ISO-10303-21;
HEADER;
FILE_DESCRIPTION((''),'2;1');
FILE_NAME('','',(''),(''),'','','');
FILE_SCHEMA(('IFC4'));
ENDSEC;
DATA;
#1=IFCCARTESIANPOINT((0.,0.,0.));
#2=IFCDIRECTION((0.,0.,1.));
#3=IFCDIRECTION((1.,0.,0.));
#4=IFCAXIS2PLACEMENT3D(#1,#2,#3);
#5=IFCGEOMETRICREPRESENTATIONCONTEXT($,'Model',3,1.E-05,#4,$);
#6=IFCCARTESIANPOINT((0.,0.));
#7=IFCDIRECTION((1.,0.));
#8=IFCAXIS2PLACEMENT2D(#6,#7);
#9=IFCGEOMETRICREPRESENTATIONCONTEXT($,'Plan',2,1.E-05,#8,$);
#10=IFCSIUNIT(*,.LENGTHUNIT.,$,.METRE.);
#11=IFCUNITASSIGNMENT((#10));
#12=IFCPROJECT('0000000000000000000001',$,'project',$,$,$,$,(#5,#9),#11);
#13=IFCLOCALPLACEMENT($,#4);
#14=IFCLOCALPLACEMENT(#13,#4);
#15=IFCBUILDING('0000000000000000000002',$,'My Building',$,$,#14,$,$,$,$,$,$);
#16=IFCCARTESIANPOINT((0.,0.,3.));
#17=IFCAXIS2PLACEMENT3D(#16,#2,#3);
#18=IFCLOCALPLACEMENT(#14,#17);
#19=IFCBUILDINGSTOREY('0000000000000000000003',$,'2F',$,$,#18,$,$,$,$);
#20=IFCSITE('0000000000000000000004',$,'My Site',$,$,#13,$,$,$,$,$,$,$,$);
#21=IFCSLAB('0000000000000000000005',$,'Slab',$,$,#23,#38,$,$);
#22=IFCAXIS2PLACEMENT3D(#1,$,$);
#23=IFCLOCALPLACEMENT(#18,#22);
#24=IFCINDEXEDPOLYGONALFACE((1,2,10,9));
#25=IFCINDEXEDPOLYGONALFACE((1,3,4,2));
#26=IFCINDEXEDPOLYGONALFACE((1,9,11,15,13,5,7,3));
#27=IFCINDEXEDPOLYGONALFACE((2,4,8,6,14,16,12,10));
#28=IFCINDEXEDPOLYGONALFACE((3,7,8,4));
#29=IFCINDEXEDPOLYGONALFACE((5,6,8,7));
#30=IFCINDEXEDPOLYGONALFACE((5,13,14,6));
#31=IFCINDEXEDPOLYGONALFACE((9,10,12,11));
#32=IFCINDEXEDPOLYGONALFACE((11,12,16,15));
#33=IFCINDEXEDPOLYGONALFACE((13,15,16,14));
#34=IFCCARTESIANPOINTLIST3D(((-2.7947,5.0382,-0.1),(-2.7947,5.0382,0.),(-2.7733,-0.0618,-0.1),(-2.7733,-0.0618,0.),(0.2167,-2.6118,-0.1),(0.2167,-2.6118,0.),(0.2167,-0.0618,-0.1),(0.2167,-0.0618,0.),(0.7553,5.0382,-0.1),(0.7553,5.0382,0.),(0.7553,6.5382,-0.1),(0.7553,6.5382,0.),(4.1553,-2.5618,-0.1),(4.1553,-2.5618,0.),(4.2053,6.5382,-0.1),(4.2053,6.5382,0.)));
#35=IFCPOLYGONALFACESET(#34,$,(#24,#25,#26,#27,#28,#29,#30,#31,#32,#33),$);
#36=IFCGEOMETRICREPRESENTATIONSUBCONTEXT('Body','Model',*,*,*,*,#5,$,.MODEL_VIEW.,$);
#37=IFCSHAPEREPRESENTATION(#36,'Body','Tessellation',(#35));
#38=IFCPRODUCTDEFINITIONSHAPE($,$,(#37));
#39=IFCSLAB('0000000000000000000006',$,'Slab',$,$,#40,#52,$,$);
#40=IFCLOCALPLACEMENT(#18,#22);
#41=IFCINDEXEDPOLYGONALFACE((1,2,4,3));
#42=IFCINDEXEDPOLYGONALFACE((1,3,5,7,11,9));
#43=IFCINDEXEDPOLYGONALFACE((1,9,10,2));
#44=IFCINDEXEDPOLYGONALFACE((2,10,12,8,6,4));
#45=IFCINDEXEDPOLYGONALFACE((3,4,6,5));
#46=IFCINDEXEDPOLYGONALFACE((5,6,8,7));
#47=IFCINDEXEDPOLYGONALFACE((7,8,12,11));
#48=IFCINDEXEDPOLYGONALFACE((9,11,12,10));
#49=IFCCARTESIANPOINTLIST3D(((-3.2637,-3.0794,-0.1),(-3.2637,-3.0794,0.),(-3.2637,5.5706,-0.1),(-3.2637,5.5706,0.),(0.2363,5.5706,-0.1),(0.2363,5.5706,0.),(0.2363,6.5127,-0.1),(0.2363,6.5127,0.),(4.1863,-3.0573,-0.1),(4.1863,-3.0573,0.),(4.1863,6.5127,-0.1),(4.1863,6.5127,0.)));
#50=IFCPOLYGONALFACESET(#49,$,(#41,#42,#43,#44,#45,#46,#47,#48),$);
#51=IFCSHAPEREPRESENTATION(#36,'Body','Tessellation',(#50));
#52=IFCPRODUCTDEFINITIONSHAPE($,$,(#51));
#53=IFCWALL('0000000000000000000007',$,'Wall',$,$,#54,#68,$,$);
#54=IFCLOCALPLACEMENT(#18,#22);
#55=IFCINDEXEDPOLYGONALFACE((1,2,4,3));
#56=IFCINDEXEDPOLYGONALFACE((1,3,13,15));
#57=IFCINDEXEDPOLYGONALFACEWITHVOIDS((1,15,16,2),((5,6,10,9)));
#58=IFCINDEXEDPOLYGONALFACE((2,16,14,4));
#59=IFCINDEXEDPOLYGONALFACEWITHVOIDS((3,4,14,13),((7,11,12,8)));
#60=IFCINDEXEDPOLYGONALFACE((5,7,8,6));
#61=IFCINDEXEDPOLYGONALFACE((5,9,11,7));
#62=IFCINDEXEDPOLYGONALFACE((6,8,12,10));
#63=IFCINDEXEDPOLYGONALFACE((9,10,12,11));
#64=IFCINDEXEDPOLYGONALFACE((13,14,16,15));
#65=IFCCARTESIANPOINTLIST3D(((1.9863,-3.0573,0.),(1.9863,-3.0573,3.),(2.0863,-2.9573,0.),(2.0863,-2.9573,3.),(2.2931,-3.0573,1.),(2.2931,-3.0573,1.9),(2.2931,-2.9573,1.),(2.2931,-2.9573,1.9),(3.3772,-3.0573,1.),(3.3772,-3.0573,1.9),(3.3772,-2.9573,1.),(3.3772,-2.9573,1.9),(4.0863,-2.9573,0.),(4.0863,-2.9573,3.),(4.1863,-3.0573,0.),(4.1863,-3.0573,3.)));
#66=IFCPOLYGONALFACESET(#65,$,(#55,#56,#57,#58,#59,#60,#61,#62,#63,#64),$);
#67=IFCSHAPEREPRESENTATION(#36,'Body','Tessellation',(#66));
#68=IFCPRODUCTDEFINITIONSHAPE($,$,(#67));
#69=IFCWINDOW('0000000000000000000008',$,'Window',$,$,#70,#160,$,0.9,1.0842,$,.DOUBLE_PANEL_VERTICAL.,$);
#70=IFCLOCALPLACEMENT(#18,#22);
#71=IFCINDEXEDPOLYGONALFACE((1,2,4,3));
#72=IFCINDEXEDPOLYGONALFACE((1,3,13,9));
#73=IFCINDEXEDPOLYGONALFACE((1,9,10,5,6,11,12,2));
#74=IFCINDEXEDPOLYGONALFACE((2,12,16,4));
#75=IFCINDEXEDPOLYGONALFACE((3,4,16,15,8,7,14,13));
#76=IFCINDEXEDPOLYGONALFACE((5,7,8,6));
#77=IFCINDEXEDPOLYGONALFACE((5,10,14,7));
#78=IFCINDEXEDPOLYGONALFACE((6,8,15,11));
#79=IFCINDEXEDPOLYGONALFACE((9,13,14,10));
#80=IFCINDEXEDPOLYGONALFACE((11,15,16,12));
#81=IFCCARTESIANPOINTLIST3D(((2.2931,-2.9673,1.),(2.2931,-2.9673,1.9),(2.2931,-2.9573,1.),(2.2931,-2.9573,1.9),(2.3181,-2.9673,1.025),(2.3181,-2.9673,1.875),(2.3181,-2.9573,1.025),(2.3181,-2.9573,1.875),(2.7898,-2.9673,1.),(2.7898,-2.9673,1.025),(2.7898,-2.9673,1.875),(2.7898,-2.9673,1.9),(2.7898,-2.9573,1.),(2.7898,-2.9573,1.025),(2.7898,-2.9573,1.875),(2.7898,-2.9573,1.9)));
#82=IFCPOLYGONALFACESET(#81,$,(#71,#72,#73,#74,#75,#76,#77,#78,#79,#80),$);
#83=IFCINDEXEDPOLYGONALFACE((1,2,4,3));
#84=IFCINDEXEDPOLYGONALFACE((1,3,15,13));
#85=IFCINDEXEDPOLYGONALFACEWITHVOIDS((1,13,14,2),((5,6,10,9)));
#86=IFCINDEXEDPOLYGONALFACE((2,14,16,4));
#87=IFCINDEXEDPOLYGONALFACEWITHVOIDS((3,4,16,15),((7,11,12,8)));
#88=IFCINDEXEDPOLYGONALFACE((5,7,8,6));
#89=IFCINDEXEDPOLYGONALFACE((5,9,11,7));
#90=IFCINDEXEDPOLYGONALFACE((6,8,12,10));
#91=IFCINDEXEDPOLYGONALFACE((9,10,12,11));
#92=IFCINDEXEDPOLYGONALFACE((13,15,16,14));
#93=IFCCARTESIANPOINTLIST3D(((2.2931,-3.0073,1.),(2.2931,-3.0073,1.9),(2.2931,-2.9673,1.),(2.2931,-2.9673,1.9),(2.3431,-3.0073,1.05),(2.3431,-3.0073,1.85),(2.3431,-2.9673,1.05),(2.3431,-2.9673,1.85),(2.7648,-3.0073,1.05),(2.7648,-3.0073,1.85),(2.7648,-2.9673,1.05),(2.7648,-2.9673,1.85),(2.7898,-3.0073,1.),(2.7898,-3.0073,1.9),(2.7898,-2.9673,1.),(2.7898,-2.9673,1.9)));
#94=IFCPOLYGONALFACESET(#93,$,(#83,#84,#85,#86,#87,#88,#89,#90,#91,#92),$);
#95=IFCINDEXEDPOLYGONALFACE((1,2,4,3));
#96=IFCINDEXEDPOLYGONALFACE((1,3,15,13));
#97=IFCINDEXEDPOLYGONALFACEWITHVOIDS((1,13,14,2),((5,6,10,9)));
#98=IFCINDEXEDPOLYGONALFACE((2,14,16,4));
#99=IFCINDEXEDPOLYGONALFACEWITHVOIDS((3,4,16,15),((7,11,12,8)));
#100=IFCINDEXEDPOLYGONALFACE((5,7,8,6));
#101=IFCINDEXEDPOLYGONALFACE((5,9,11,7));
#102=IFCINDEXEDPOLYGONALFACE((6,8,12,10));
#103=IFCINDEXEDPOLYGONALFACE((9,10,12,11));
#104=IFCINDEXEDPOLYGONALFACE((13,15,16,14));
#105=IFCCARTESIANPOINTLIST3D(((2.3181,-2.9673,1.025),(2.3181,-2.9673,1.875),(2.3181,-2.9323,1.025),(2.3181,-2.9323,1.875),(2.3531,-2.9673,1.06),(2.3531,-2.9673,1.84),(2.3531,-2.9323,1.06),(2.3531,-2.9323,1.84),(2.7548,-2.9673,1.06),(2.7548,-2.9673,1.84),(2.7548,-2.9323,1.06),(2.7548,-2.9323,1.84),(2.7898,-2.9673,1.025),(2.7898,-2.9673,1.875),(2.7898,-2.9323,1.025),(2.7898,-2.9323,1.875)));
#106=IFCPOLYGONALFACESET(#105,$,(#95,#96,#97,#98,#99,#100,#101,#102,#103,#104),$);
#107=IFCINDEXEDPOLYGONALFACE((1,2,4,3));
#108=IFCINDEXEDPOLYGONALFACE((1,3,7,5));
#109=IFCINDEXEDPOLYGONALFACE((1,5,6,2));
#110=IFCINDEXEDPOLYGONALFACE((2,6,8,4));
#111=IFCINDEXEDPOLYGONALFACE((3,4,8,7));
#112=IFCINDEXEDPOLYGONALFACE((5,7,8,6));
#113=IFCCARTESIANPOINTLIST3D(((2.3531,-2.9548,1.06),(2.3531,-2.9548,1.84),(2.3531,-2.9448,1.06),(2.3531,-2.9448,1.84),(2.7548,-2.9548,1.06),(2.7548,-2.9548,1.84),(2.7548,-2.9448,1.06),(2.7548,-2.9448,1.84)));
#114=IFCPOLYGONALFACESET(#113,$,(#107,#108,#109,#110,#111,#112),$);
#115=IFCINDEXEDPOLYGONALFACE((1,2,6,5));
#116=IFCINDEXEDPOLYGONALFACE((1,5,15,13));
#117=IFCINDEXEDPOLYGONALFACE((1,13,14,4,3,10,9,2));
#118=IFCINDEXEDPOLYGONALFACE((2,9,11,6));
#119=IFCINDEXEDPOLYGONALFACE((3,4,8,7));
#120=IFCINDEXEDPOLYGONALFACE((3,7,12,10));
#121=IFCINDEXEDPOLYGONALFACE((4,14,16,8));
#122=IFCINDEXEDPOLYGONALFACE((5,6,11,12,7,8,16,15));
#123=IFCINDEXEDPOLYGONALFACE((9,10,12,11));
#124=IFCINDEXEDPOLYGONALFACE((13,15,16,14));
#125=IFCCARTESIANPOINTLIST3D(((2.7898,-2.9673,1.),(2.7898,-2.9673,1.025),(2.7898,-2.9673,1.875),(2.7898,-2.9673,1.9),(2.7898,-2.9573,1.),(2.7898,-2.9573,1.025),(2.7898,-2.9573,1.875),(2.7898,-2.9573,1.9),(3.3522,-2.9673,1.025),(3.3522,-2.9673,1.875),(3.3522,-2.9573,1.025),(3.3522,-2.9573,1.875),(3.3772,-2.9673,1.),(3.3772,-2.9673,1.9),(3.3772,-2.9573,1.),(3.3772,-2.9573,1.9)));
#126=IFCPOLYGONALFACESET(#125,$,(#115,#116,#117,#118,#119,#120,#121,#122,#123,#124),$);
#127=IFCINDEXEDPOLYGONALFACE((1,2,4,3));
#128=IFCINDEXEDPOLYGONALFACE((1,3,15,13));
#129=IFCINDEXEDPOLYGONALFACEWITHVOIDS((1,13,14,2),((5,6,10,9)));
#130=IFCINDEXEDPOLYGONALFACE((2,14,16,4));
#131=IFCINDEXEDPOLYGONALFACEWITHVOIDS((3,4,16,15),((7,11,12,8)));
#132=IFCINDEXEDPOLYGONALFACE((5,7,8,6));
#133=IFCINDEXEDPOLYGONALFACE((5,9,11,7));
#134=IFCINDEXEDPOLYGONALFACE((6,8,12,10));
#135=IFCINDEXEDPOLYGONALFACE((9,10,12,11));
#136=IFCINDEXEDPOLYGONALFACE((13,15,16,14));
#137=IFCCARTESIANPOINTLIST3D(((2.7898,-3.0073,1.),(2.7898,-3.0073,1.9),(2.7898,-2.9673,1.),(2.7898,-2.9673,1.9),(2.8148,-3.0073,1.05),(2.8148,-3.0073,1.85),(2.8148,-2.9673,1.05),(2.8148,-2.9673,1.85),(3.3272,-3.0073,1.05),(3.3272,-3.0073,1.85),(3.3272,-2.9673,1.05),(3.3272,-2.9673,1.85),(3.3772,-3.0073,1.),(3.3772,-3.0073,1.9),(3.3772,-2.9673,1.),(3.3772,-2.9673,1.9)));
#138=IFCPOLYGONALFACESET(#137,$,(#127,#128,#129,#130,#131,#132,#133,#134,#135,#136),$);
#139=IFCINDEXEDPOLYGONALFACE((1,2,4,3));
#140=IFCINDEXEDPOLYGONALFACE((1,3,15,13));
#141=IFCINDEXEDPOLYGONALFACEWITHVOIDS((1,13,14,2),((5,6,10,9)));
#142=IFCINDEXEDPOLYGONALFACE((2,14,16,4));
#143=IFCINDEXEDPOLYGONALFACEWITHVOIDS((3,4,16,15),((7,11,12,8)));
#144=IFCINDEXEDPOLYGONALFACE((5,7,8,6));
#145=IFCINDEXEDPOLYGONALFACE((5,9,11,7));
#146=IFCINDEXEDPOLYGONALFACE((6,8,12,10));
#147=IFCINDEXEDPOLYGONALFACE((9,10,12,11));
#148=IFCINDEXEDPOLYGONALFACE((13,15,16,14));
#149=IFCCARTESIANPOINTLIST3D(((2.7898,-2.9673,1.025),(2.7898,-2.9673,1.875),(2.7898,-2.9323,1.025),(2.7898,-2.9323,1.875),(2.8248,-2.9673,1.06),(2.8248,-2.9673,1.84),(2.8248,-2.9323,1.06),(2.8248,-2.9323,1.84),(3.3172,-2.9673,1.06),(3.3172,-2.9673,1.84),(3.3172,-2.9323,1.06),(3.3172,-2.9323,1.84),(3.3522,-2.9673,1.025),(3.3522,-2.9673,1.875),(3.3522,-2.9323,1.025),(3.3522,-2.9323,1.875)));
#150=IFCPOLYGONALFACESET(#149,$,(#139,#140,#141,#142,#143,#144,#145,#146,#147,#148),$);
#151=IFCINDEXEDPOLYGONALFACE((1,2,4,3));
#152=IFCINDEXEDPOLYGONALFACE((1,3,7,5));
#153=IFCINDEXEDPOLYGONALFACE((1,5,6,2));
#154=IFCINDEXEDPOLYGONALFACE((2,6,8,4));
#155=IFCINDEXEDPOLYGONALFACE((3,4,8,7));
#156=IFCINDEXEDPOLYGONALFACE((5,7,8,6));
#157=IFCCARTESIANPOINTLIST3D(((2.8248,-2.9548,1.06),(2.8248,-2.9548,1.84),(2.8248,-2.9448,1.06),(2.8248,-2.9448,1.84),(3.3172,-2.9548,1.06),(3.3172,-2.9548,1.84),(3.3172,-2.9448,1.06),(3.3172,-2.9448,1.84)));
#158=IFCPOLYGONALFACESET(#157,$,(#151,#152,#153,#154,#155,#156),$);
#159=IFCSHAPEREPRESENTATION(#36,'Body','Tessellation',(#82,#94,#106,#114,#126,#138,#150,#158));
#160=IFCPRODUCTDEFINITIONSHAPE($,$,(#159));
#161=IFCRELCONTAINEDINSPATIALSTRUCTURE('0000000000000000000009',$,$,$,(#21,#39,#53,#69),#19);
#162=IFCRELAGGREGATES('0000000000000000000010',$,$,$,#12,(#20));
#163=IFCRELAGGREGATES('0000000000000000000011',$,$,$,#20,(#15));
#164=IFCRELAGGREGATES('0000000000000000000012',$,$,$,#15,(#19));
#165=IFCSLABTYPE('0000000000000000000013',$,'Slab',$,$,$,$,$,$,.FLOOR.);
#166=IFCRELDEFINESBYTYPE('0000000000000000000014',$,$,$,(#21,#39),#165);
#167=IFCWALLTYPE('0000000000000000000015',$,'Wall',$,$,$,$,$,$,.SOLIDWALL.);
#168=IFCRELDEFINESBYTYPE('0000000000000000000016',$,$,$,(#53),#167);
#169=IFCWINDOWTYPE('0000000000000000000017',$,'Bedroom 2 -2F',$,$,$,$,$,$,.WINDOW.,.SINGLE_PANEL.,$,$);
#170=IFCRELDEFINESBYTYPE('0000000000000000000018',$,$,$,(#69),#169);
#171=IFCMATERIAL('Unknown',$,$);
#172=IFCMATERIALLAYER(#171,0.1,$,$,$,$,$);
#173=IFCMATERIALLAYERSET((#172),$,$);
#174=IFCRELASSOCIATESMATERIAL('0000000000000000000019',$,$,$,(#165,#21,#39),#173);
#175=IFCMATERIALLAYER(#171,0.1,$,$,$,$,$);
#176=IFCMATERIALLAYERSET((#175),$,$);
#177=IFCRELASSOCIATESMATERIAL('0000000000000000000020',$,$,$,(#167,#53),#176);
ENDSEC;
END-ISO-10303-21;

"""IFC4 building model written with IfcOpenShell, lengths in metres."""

from ifc_helpers import new_model, entity, si_unit, frame, origin_with_axes, origin_2d_with_axis, place, context, subcontext, project, spatial, line, indexed_curve, outline, extrude, shape, source, transform, mapped, material, layer, layer_set, layer_usage, type_object, type_shapes, element, fill, save


model = new_model("IFC4")

# Units and contexts
model_context = context("Model", 3, precision=1e-05, world=origin_with_axes())
plan_context = context("Plan", 2, precision=1e-05, world=origin_2d_with_axis())
body_context_1 = subcontext(model_context, "Body", "Model", "MODEL_VIEW")
body_context_2 = subcontext(plan_context, "Body", "Plan", "PLAN_VIEW")
ifc_project = project(units=[si_unit("LENGTHUNIT", "METRE")], contexts=[model_context, plan_context])

# Site, building, storey
site_placement = place(None, origin_with_axes())
site = spatial("IfcSite", under=ifc_project, at=site_placement, Name="My Site")
building_placement = place(site_placement, origin_with_axes())
building = spatial("IfcBuilding", under=site, at=building_placement, Name="My Building")
storey_placement = place(building_placement, frame((0.0, 0.0, 3.0), z_axis=(0.0, 0.0, 1.0), x_axis=(1.0, 0.0, 0.0)))
storey = spatial("IfcBuildingStorey", under=building, at=storey_placement, Name="2F")

# Slabs
ifc_material = material(Name="Unknown")
ifc_layer_1 = layer(ifc_material, 0.1)
ifc_layer_set_1 = layer_set([ifc_layer_1])
ifc_layer_usage_1 = layer_usage(ifc_layer_set_1, "AXIS3", "POSITIVE", -0.1)
slab_type = type_object("IfcSlabType", Name="Slab", PredefinedType="FLOOR", material=ifc_layer_set_1)
slab_1_placement = place(storey_placement, frame((0.7553, 6.5382, 0.0), z_axis=(0.0, 0.0, 1.0), x_axis=(1.0, 0.0, 0.0)))
element("IfcSlab", 1, at=slab_1_placement, inside=storey, type_object=slab_type, material=ifc_layer_usage_1, Name="Slab", context=body_context_1, shape_type="SweptSolid", body=[
    extrude(outline(indexed_curve([(0.0, 0.0), (0.0, -1.5), (-3.55, -1.5), (-3.5286, -6.6), (-0.5386, -6.6), (-0.5386, -9.15), (3.4, -9.1), (3.45, 0.0), (0.0, 0.0)])), frame((0.0, 0.0, -0.1), z_axis=(0.0, 0.0, 1.0), x_axis=(1.0, 0.0, 0.0)), (0.0, 0.0, 1.0), 0.1),
])
ifc_layer_usage_2 = layer_usage(ifc_layer_set_1, "AXIS3", "POSITIVE", -0.1)
slab_2_placement = place(storey_placement, frame((4.1863, -3.0573, 0.0), z_axis=(0.0, 0.0, 1.0), x_axis=(1.0, 0.0, 0.0)))
element("IfcSlab", 2, at=slab_2_placement, inside=storey, type_object=slab_type, material=ifc_layer_usage_2, Name="Slab", context=body_context_1, shape_type="SweptSolid", body=[
    extrude(outline(indexed_curve([(0.0, 0.0), (0.0, 9.57), (-3.95, 9.57), (-3.95, 8.6279), (-7.45, 8.6279), (-7.45, -0.0221), (0.0, 0.0)])), frame((0.0, 0.0, -0.1), z_axis=(0.0, 0.0, 1.0), x_axis=(1.0, 0.0, 0.0)), (0.0, 0.0, 1.0), 0.1),
])

# Wall, opening, window
ifc_layer_2 = layer(ifc_material, 0.1)
ifc_layer_set_2 = layer_set([ifc_layer_2])
ifc_layer_usage_3 = layer_usage(ifc_layer_set_2, "AXIS2", "POSITIVE", 0.0)
wall_type = type_object("IfcWallType", Name="Wall", PredefinedType="SOLIDWALL", material=ifc_layer_set_2)
wall_1_placement = place(storey_placement, frame((1.9863, -3.0573, 0.0), z_axis=(0.0, 0.0, 1.0), x_axis=(1.0, 0.0, 0.0)))
wall_1 = element("IfcWall", 3, at=wall_1_placement, inside=storey, type_object=wall_type, material=ifc_layer_usage_3, Name="Wall", context=body_context_1, shape_type="SweptSolid", body=[
    extrude(outline(indexed_curve([(0.0, 0.0), (0.1, 0.1), (2.1, 0.1), (2.2, 0.0)], segments=[line(1, 2, 3, 4, 1)])), origin_with_axes(), (0.0, 0.0, 1.0), 3.0),
])
shared_shape_1 = source(origin_with_axes(), body_context_1, "Body", "SweptSolid", [
    extrude(outline(indexed_curve([(0.0, 0.0), (1.0842, 0.0), (1.0842, 0.9), (0.0, 0.9)], segments=[line(1, 2, 3, 4, 1)])), frame((0.0, -0.6, 0.0), z_axis=(0.0, -1.0, 0.0), x_axis=(1.0, 0.0, 0.0)), (0.0, 0.0, -1.0), 1.2),
])
opening_1_placement = place(wall_1_placement, frame((0.3068, 0.0, 1.0), z_axis=(0.0, 0.0, 1.0), x_axis=(1.0, 0.0, 0.0)))
opening_1 = element("IfcOpeningElement", 4, at=opening_1_placement, cuts=wall_1, PredefinedType="OPENING", context=body_context_1, shape_type="MappedRepresentation", body=[
    mapped(shared_shape_1, transform((0.0, 0.0, 0.0), x_axis=(1.0, 0.0, 0.0), y_axis=(0.0, 1.0, 0.0), z_axis=(0.0, 0.0, 1.0), scale=1.0)),
])
window_type_1 = type_object("IfcWindowType", Name="Bedroom 2 -2F", PartitioningType="SINGLE_PANEL", PredefinedType="WINDOW")
shared_shape_2 = source(origin_with_axes(), body_context_1, "Body", "SweptSolid", [
    extrude(outline(indexed_curve([(0.4967, 0.0), (0.0, 0.0), (0.0, 0.9), (0.4967, 0.9), (0.4967, 0.875), (0.025, 0.875), (0.025, 0.025), (0.4967, 0.025)], segments=[line(1, 2, 3, 4, 5, 6, 7, 8, 1)])), frame((0.0, 0.09, 0.0), z_axis=(0.0, -1.0, 0.0), x_axis=(1.0, 0.0, 0.0)), (0.0, 0.0, -1.0), 0.01),
    extrude(outline(indexed_curve([(0.0, 0.0), (0.4967, 0.0), (0.4967, 0.9), (0.0, 0.9)], segments=[line(1, 2, 3, 4, 1)]), holes=[indexed_curve([(0.05, 0.05), (0.4717, 0.05), (0.4717, 0.85), (0.05, 0.85)], segments=[line(1, 2, 3, 4, 1)])]), frame((0.0, 0.05, 0.0), z_axis=(0.0, -1.0, 0.0), x_axis=(1.0, 0.0, 0.0)), (0.0, 0.0, -1.0), 0.04),
    extrude(outline(indexed_curve([(0.0, 0.0), (0.4717, 0.0), (0.4717, 0.85), (0.0, 0.85)], segments=[line(1, 2, 3, 4, 1)]), holes=[indexed_curve([(0.035, 0.035), (0.4367, 0.035), (0.4367, 0.815), (0.035, 0.815)], segments=[line(1, 2, 3, 4, 1)])]), frame((0.025, 0.09, 0.025), z_axis=(0.0, -1.0, 0.0), x_axis=(1.0, 0.0, 0.0)), (0.0, 0.0, -1.0), 0.035),
    extrude(outline(indexed_curve([(0.035, 0.035), (0.4367, 0.035), (0.4367, 0.815), (0.035, 0.815)], segments=[line(1, 2, 3, 4, 1)])), frame((0.025, 0.1025, 0.025), z_axis=(0.0, -1.0, 0.0), x_axis=(1.0, 0.0, 0.0)), (0.0, 0.0, -1.0), 0.01),
    extrude(outline(indexed_curve([(0.0, 0.9), (0.5874, 0.9), (0.5874, 0.0), (0.0, 0.0), (0.0, 0.025), (0.5624, 0.025), (0.5624, 0.875), (0.0, 0.875)], segments=[line(1, 2, 3, 4, 5, 6, 7, 8, 1)])), frame((0.4967, 0.09, 0.0), z_axis=(0.0, -1.0, 0.0), x_axis=(1.0, 0.0, 0.0)), (0.0, 0.0, -1.0), 0.01),
    extrude(outline(indexed_curve([(0.0, 0.0), (0.5874, 0.0), (0.5874, 0.9), (0.0, 0.9)], segments=[line(1, 2, 3, 4, 1)]), holes=[indexed_curve([(0.025, 0.05), (0.5374, 0.05), (0.5374, 0.85), (0.025, 0.85)], segments=[line(1, 2, 3, 4, 1)])]), frame((0.4967, 0.05, 0.0), z_axis=(0.0, -1.0, 0.0), x_axis=(1.0, 0.0, 0.0)), (0.0, 0.0, -1.0), 0.04),
    extrude(outline(indexed_curve([(0.0, 0.0), (0.5624, 0.0), (0.5624, 0.85), (0.0, 0.85)], segments=[line(1, 2, 3, 4, 1)]), holes=[indexed_curve([(0.035, 0.035), (0.5274, 0.035), (0.5274, 0.815), (0.035, 0.815)], segments=[line(1, 2, 3, 4, 1)])]), frame((0.4967, 0.09, 0.025), z_axis=(0.0, -1.0, 0.0), x_axis=(1.0, 0.0, 0.0)), (0.0, 0.0, -1.0), 0.035),
    extrude(outline(indexed_curve([(0.035, 0.035), (0.5274, 0.035), (0.5274, 0.815), (0.035, 0.815)], segments=[line(1, 2, 3, 4, 1)])), frame((0.4967, 0.1025, 0.025), z_axis=(0.0, -1.0, 0.0), x_axis=(1.0, 0.0, 0.0)), (0.0, 0.0, -1.0), 0.01),
])
shared_shape_3 = source(origin_with_axes(), body_context_2, "Body", "Curve2D", [
    entity("IfcIndexedPolyCurve", entity("IfcCartesianPointList2D", [[0.05, 0.05], [0.4717, 0.05]])),
    entity("IfcIndexedPolyCurve", entity("IfcCartesianPointList2D", [[0.0, 0.1], [0.025, 0.1], [0.025, 0.09], [0.05, 0.09], [0.05, 0.05], [0.0, 0.05]]), [entity("IfcLineIndex", [1, 2, 3, 4, 5, 6, 1])]),
    entity("IfcIndexedPolyCurve", entity("IfcCartesianPointList2D", [[0.4967, 0.1], [0.4967, 0.1], [0.4967, 0.09], [0.4717, 0.09], [0.4717, 0.05], [0.4967, 0.05]])),
    entity("IfcIndexedPolyCurve", entity("IfcCartesianPointList2D", [[0.025, 0.09], [0.06, 0.09], [0.06, 0.125], [0.025, 0.125]]), [entity("IfcLineIndex", [1, 2, 3, 4, 1])]),
    entity("IfcIndexedPolyCurve", entity("IfcCartesianPointList2D", [[0.4967, 0.09], [0.4617, 0.09], [0.4617, 0.125], [0.4967, 0.125]]), [entity("IfcLineIndex", [1, 2, 3, 4, 1])]),
    entity("IfcIndexedPolyCurve", entity("IfcCartesianPointList2D", [[0.06, 0.09], [0.4617, 0.09]])),
    entity("IfcIndexedPolyCurve", entity("IfcCartesianPointList2D", [[0.06, 0.125], [0.4617, 0.125]])),
    entity("IfcIndexedPolyCurve", entity("IfcCartesianPointList2D", [[0.06, 0.1075], [0.4617, 0.1075]])),
    entity("IfcIndexedPolyCurve", entity("IfcCartesianPointList2D", [[0.5217, 0.05], [1.0342, 0.05]])),
    entity("IfcIndexedPolyCurve", entity("IfcCartesianPointList2D", [[0.4967, 0.1], [0.4967, 0.1], [0.4967, 0.09], [0.5217, 0.09], [0.5217, 0.05], [0.4967, 0.05]])),
    entity("IfcIndexedPolyCurve", entity("IfcCartesianPointList2D", [[1.0842, 0.1], [1.0592, 0.1], [1.0592, 0.09], [1.0342, 0.09], [1.0342, 0.05], [1.0842, 0.05]]), [entity("IfcLineIndex", [1, 2, 3, 4, 5, 6, 1])]),
    entity("IfcIndexedPolyCurve", entity("IfcCartesianPointList2D", [[0.4967, 0.09], [0.5317, 0.09], [0.5317, 0.125], [0.4967, 0.125]]), [entity("IfcLineIndex", [1, 2, 3, 4, 1])]),
    entity("IfcIndexedPolyCurve", entity("IfcCartesianPointList2D", [[1.0592, 0.09], [1.0242, 0.09], [1.0242, 0.125], [1.0592, 0.125]]), [entity("IfcLineIndex", [1, 2, 3, 4, 1])]),
    entity("IfcIndexedPolyCurve", entity("IfcCartesianPointList2D", [[0.5317, 0.09], [1.0242, 0.09]])),
    entity("IfcIndexedPolyCurve", entity("IfcCartesianPointList2D", [[0.5317, 0.125], [1.0242, 0.125]])),
    entity("IfcIndexedPolyCurve", entity("IfcCartesianPointList2D", [[0.5317, 0.1075], [1.0242, 0.1075]])),
])
type_shapes(window_type_1, [shared_shape_2, shared_shape_3])
window_1_placement = place(opening_1_placement, origin_with_axes())
window_1 = element("IfcWindow", 5, at=window_1_placement, inside=storey, type_object=window_type_1, Name="Window", OverallHeight=0.9, OverallWidth=1.0842, PartitioningType="DOUBLE_PANEL_VERTICAL", shapes=[
    shape(body_context_1, "Body", "MappedRepresentation", [mapped(shared_shape_2, transform((0.0, 0.0, 0.0), x_axis=(1.0, 0.0, 0.0), y_axis=(0.0, 1.0, 0.0), z_axis=(0.0, 0.0, 1.0), scale=1.0))]),
    shape(body_context_2, "Body", "MappedRepresentation", [mapped(shared_shape_3, transform((0.0, 0.0, 0.0), x_axis=(1.0, 0.0, 0.0), y_axis=(0.0, 1.0, 0.0), z_axis=(0.0, 0.0, 1.0), scale=1.0))]),
])
fill(opening_1, window_1)

save(model, "model.ifc")
